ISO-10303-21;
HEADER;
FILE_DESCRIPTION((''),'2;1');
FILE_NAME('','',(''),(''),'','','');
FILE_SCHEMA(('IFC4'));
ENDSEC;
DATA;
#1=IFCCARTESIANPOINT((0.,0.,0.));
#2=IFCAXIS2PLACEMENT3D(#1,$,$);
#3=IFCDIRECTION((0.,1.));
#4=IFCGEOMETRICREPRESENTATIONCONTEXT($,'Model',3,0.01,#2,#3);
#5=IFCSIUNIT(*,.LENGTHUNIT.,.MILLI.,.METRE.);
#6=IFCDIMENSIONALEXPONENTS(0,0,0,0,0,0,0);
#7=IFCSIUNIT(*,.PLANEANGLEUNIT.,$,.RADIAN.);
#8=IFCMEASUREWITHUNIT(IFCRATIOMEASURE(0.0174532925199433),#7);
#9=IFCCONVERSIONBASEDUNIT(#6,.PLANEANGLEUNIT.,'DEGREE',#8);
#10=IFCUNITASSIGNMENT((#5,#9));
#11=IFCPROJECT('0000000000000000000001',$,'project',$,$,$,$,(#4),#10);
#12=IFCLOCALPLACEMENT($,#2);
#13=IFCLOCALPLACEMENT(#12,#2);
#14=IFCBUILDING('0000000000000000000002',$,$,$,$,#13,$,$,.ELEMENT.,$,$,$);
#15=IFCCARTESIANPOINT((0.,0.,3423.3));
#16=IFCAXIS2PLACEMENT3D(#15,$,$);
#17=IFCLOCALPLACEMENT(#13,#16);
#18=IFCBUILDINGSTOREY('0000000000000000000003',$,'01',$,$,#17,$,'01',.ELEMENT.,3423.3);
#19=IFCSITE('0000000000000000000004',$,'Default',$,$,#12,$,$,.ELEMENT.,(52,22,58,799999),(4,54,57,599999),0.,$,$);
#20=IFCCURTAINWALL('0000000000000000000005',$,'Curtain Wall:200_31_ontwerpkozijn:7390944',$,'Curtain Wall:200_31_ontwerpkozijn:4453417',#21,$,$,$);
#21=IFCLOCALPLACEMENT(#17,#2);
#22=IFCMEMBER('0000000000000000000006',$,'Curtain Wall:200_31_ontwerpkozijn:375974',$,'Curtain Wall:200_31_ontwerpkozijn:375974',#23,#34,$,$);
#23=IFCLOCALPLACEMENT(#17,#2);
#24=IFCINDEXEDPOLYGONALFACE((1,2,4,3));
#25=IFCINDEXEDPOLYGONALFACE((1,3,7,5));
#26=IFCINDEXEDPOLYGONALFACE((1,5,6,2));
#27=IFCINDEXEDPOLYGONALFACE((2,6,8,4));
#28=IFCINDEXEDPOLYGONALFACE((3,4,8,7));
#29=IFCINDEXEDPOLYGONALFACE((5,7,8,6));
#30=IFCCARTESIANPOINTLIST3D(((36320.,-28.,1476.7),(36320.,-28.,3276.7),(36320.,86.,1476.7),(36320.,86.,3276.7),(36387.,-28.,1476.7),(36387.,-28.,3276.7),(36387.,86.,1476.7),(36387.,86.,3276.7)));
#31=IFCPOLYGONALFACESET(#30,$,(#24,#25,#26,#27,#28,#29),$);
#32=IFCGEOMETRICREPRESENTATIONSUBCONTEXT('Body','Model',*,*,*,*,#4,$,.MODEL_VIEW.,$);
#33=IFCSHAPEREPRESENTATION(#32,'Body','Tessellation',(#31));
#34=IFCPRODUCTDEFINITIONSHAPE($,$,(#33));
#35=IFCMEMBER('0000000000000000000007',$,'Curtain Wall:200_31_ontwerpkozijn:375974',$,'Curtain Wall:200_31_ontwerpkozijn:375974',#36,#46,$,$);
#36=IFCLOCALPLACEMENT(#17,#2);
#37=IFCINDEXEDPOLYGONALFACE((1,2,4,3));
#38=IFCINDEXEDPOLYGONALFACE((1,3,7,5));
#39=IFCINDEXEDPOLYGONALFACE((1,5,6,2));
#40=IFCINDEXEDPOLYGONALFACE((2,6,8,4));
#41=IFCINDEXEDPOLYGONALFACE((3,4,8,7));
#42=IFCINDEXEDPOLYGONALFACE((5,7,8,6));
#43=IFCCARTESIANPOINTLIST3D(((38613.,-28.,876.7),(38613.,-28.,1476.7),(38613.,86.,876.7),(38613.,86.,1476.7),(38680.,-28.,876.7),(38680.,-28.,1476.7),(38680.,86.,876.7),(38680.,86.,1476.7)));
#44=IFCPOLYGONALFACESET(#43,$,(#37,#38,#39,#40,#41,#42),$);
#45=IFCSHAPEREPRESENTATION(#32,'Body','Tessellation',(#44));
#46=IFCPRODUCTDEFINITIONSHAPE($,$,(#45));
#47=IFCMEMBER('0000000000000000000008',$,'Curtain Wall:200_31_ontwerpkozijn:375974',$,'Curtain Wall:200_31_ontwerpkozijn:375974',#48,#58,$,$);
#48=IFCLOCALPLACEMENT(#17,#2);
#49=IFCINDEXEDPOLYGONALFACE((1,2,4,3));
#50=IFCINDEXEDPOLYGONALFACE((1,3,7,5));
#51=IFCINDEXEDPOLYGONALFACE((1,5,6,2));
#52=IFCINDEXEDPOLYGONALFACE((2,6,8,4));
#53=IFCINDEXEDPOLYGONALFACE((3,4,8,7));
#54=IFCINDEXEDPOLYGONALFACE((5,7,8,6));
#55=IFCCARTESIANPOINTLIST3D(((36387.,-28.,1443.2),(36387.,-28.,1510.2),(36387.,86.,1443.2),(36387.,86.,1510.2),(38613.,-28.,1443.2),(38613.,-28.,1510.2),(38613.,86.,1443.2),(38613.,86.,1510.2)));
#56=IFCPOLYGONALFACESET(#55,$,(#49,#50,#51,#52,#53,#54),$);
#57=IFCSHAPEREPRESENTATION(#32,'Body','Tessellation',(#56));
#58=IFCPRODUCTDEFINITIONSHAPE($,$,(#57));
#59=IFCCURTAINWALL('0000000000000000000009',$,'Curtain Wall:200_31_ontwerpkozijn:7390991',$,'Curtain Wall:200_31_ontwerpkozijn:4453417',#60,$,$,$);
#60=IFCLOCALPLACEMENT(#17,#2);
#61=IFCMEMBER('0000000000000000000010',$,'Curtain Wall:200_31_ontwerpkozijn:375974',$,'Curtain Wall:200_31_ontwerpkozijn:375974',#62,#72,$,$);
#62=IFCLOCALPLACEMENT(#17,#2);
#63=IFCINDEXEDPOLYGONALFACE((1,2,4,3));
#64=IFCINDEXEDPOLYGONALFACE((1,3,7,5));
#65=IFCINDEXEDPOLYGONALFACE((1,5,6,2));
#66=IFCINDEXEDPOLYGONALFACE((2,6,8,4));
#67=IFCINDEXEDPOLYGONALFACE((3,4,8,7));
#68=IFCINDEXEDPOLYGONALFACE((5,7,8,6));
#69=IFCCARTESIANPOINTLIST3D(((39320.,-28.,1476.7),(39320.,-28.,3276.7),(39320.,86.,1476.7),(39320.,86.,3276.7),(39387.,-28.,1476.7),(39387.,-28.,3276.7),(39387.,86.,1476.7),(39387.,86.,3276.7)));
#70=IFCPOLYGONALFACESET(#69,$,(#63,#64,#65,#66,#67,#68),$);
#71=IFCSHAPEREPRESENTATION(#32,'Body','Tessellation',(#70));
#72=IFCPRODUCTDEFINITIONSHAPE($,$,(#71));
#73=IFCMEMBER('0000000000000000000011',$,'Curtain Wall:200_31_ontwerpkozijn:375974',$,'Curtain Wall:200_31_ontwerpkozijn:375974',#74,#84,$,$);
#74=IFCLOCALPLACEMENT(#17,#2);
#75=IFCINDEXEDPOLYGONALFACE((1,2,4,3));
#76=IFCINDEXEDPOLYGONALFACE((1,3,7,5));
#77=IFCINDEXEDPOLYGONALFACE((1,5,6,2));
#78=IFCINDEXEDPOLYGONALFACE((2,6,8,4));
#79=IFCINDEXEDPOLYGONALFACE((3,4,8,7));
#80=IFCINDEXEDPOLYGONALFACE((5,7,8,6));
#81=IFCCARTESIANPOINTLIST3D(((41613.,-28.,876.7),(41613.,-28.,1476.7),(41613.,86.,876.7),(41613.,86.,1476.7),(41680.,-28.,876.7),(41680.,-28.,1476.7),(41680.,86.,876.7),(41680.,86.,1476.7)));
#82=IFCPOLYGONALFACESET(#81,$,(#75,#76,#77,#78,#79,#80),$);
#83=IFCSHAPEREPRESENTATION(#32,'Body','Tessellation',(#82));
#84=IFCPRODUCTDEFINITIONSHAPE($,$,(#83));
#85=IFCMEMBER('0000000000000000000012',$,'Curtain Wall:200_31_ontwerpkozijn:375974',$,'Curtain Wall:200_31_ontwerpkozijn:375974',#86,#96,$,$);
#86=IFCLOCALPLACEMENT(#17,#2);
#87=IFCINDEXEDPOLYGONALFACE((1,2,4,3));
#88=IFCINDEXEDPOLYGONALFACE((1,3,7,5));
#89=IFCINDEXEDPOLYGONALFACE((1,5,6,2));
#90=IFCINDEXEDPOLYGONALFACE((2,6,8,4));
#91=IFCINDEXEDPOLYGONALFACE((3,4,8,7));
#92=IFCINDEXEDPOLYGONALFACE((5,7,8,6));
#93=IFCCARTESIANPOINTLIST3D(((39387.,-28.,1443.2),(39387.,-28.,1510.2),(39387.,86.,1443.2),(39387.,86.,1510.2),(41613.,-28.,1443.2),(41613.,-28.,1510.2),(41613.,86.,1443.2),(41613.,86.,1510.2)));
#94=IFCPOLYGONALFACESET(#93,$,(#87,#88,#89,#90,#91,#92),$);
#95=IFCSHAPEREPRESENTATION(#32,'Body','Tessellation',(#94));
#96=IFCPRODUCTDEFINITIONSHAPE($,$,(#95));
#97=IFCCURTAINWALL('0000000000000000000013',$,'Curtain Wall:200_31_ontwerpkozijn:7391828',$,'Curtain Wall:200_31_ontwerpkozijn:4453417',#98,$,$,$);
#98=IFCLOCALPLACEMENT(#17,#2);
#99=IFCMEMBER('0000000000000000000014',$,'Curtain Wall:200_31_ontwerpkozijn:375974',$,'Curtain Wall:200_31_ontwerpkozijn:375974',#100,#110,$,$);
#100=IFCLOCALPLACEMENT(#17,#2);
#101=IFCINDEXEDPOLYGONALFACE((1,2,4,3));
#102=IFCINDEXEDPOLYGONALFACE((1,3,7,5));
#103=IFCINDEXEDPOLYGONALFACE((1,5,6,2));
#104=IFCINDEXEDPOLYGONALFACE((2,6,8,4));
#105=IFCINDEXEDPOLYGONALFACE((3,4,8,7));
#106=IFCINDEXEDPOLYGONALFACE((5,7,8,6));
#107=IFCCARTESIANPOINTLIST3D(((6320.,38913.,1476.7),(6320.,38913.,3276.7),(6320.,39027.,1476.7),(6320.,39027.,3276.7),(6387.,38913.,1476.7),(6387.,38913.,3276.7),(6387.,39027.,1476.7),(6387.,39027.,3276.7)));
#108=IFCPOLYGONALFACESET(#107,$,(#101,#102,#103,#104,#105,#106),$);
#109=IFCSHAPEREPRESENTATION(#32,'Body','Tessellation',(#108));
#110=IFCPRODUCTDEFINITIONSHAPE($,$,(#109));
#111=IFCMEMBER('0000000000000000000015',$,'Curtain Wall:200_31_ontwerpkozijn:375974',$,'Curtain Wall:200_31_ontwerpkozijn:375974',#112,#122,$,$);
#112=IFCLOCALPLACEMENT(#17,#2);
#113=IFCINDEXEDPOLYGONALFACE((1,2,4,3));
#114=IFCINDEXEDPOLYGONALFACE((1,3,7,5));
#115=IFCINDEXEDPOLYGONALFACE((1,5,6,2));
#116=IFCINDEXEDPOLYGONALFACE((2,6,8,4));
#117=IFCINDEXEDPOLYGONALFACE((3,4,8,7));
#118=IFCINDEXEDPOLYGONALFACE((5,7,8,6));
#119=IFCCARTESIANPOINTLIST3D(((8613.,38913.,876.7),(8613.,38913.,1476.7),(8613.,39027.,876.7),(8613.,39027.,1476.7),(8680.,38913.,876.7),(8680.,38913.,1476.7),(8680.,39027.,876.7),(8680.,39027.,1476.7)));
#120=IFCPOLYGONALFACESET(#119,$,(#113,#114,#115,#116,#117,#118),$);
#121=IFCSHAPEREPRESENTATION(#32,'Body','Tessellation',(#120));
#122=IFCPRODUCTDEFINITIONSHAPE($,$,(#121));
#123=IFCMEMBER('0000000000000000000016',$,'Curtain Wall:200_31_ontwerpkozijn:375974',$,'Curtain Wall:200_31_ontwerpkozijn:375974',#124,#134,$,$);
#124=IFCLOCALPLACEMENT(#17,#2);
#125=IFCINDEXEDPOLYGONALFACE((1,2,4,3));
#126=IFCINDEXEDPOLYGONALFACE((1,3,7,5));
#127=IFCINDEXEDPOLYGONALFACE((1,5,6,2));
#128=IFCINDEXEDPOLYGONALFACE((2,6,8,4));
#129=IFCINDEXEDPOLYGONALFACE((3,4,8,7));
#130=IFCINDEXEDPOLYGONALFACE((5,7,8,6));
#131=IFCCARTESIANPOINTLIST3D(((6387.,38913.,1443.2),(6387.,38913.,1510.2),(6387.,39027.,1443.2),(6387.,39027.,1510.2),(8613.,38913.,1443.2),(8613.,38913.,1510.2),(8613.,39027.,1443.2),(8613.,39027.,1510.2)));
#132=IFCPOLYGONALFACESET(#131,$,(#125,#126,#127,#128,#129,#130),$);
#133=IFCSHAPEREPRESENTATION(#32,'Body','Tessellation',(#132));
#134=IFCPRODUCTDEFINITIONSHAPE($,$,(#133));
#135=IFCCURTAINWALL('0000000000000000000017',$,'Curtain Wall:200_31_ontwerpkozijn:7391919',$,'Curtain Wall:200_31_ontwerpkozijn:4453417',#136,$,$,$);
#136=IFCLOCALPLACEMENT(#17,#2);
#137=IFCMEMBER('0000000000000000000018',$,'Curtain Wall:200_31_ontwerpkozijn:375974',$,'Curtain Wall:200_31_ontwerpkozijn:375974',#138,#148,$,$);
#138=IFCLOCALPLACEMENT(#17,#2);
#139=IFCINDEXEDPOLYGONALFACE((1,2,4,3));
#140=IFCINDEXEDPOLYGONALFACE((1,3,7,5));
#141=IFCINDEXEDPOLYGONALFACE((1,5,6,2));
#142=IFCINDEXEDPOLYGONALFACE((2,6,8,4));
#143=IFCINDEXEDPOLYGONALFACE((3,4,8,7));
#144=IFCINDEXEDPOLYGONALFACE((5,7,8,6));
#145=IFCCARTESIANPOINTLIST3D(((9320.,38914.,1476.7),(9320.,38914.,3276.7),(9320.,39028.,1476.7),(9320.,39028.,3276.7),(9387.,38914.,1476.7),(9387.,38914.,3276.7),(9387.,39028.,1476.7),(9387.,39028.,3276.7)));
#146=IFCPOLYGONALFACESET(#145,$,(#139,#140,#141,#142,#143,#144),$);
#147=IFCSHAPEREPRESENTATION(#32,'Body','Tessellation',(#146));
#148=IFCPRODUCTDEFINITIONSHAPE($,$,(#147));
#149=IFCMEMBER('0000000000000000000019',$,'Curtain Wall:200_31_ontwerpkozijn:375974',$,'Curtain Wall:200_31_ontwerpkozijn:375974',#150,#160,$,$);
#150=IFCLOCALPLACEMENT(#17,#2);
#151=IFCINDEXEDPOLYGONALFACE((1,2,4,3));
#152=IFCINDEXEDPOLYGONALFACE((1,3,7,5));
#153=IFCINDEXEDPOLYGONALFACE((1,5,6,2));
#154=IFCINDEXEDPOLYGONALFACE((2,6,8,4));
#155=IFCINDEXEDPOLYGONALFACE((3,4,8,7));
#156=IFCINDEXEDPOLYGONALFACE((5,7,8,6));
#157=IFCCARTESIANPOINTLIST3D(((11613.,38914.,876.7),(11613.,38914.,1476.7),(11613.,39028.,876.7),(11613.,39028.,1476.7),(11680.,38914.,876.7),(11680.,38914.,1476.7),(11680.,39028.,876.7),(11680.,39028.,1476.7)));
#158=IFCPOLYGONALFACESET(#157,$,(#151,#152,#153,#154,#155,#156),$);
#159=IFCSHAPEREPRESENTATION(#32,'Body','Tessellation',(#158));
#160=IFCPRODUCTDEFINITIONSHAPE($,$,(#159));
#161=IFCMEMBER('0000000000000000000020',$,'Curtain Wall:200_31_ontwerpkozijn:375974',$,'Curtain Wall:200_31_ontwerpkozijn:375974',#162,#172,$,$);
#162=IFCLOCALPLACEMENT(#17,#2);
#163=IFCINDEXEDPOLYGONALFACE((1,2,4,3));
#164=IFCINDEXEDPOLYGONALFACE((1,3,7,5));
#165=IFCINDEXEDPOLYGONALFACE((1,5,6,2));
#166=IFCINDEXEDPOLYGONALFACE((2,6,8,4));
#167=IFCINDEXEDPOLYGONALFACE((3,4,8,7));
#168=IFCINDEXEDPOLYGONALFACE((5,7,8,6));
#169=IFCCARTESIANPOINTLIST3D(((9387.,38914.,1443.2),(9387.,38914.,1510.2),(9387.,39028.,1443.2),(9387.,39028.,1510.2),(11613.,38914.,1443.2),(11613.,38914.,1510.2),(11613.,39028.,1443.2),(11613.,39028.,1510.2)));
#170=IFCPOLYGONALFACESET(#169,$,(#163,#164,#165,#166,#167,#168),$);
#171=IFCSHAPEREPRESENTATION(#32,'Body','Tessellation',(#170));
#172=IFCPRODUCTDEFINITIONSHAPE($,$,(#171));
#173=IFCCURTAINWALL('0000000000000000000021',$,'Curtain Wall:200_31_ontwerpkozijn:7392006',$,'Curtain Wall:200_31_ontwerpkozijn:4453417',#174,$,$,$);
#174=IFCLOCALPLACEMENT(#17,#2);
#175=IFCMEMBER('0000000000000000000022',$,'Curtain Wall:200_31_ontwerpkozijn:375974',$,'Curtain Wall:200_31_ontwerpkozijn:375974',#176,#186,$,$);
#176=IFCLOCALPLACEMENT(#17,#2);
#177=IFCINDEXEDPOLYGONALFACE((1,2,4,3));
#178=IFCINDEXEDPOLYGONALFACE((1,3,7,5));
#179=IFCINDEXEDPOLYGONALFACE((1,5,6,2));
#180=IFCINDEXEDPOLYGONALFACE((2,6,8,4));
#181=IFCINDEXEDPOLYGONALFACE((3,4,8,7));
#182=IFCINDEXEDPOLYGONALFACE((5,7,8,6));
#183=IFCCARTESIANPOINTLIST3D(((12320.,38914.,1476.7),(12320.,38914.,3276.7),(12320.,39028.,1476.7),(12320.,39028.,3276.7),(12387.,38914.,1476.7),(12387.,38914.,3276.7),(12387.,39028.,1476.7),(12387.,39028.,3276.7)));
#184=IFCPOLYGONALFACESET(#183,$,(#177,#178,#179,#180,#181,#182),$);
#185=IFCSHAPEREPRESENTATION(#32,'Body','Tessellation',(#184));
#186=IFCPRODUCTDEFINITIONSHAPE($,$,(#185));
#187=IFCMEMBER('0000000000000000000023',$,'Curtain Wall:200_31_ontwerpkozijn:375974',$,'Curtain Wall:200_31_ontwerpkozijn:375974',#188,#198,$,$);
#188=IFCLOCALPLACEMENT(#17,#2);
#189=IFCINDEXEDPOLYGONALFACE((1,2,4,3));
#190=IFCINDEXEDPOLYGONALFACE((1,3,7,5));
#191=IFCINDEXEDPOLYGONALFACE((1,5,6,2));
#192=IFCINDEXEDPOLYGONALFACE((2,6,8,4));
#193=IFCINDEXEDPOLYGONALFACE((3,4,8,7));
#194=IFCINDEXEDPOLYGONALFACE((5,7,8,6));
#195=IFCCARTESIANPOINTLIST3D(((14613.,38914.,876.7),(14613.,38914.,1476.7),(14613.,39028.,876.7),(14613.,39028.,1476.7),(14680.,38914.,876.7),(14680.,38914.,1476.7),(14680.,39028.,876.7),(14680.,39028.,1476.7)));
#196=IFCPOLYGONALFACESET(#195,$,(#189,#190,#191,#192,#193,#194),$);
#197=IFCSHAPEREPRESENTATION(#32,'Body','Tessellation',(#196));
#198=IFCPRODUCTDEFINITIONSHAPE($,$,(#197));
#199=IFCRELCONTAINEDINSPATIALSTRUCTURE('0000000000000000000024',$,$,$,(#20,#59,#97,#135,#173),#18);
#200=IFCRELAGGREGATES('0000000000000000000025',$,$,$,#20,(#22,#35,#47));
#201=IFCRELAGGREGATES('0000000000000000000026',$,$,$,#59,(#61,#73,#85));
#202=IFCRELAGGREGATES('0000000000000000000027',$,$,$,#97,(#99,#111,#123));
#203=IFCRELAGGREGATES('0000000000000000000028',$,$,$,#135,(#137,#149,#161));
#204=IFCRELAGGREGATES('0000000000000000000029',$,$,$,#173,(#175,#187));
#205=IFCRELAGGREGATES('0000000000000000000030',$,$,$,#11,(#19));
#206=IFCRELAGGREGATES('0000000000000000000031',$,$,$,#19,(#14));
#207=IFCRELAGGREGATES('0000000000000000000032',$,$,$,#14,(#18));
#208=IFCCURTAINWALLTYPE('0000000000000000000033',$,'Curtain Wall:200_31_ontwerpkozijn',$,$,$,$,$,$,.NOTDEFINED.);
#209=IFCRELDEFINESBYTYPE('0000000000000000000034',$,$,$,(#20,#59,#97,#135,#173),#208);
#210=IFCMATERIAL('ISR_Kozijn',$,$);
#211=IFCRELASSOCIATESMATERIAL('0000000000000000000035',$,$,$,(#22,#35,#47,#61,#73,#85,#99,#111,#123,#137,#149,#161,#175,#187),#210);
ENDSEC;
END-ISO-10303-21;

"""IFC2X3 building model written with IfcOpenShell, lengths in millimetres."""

from ifc_helpers import new_model, entity, si_unit, converted_unit, direction, frame, frame_2d, origin, origin_2d_with_axis, place, context, subcontext, project, spatial, rectangle, extrude, material, type_object, element, aggregate, save


model = new_model("IFC2X3")

# Units and contexts
model_context = context("Model", 3, precision=0.01, world=origin(), true_north=direction((0.0, 1.0)))
body_context = subcontext(model_context, "Body", "Model", "MODEL_VIEW")
ifc_project = project(units=[si_unit("LENGTHUNIT", "METRE", prefix="MILLI"), converted_unit("PLANEANGLEUNIT", "DEGREE", entity("IfcRatioMeasure", 0.0174532925199433), si_unit("PLANEANGLEUNIT", "RADIAN"), dimensions=[0, 0, 0, 0, 0, 0, 0])], contexts=[model_context])

# Site, building, storey
site_placement = place(None, origin())
site = spatial("IfcSite", under=ifc_project, at=site_placement, Name="Default", CompositionType="ELEMENT", RefLatitude=(52, 22, 58, 799999), RefLongitude=(4, 54, 57, 599999), RefElevation=0.0)
building_placement = place(site_placement, origin())
building = spatial("IfcBuilding", under=site, at=building_placement, CompositionType="ELEMENT")
storey_placement = place(building_placement, frame((0.0, 0.0, 3423.3)))
storey = spatial("IfcBuildingStorey", under=building, at=storey_placement, Name="01", LongName="01", CompositionType="ELEMENT", Elevation=3423.3)

# Curtain walls, members
curtain_wall_type = type_object("IfcCurtainWallType", Name="Curtain Wall:200_31_ontwerpkozijn", PredefinedType="NOTDEFINED")
curtain_wall_1_placement = place(storey_placement, frame((0.0, 0.0, -3423.3)))
curtain_wall_1 = element("IfcCurtainWall", 1, at=curtain_wall_1_placement, inside=storey, type_object=curtain_wall_type, Name="Curtain Wall:200_31_ontwerpkozijn:7390944", ObjectType="Curtain Wall:200_31_ontwerpkozijn:4453417")
ifc_material = material(Name="ISR_Kozijn")
member_1_placement = place(curtain_wall_1_placement, frame((0.0, 0.0, 3423.3)))
member_1 = element("IfcMember", 2, at=member_1_placement, material=ifc_material, Name="Curtain Wall:200_31_ontwerpkozijn:375974", ObjectType="Curtain Wall:200_31_ontwerpkozijn:375974", context=body_context, shape_type="SweptSolid", body=[
    extrude(rectangle(XDim=67.0, YDim=114.0, at=origin_2d_with_axis()), frame((36353.5, 29.0, 1476.7), z_axis=(0.0, 0.0, 1.0), x_axis=(-1.0, 0.0, 0.0)), (0.0, 0.0, 1.0), 1800.0),
])
member_2_placement = place(curtain_wall_1_placement, frame((0.0, 0.0, 3423.3)))
member_2 = element("IfcMember", 3, at=member_2_placement, material=ifc_material, Name="Curtain Wall:200_31_ontwerpkozijn:375974", ObjectType="Curtain Wall:200_31_ontwerpkozijn:375974", context=body_context, shape_type="SweptSolid", body=[
    extrude(rectangle(XDim=67.0, YDim=114.0, at=origin_2d_with_axis()), frame((38646.5, 29.0, 1476.7), z_axis=(0.0, 0.0, -1.0), x_axis=(-1.0, 0.0, 0.0)), (0.0, 0.0, 1.0), 600.0),
])
member_3_placement = place(curtain_wall_1_placement, frame((0.0, 0.0, 3423.3)))
member_3 = element("IfcMember", 4, at=member_3_placement, material=ifc_material, Name="Curtain Wall:200_31_ontwerpkozijn:375974", ObjectType="Curtain Wall:200_31_ontwerpkozijn:375974", context=body_context, shape_type="SweptSolid", body=[
    extrude(rectangle(XDim=67.0, YDim=114.0, at=origin_2d_with_axis()), frame((36387.0, 29.0, 1476.7), z_axis=(1.0, 0.0, 0.0), x_axis=(0.0, 0.0, -1.0)), (0.0, 0.0, 1.0), 2226.0),
])
aggregate(curtain_wall_1, [member_1, member_2, member_3])
curtain_wall_2_placement = place(storey_placement, frame((0.0, 0.0, -3423.3)))
curtain_wall_2 = element("IfcCurtainWall", 5, at=curtain_wall_2_placement, inside=storey, type_object=curtain_wall_type, Name="Curtain Wall:200_31_ontwerpkozijn:7390991", ObjectType="Curtain Wall:200_31_ontwerpkozijn:4453417")
member_4_placement = place(curtain_wall_2_placement, frame((0.0, 0.0, 3423.3)))
member_4 = element("IfcMember", 6, at=member_4_placement, material=ifc_material, Name="Curtain Wall:200_31_ontwerpkozijn:375974", ObjectType="Curtain Wall:200_31_ontwerpkozijn:375974", context=body_context, shape_type="SweptSolid", body=[
    extrude(rectangle(XDim=67.0, YDim=114.0, at=origin_2d_with_axis()), frame((39353.5, 29.0, 1476.7), z_axis=(0.0, 0.0, 1.0), x_axis=(-1.0, 0.0, 0.0)), (0.0, 0.0, 1.0), 1800.0),
])
member_5_placement = place(curtain_wall_2_placement, frame((0.0, 0.0, 3423.3)))
member_5 = element("IfcMember", 7, at=member_5_placement, material=ifc_material, Name="Curtain Wall:200_31_ontwerpkozijn:375974", ObjectType="Curtain Wall:200_31_ontwerpkozijn:375974", context=body_context, shape_type="SweptSolid", body=[
    extrude(rectangle(XDim=67.0, YDim=114.0, at=origin_2d_with_axis()), frame((41646.5, 29.0, 1476.7), z_axis=(0.0, 0.0, -1.0), x_axis=(-1.0, 0.0, 0.0)), (0.0, 0.0, 1.0), 600.0),
])
member_6_placement = place(curtain_wall_2_placement, frame((0.0, 0.0, 3423.3)))
member_6 = element("IfcMember", 8, at=member_6_placement, material=ifc_material, Name="Curtain Wall:200_31_ontwerpkozijn:375974", ObjectType="Curtain Wall:200_31_ontwerpkozijn:375974", context=body_context, shape_type="SweptSolid", body=[
    extrude(rectangle(XDim=67.0, YDim=114.0, at=origin_2d_with_axis()), frame((39387.0, 29.0, 1476.7), z_axis=(1.0, 0.0, 0.0), x_axis=(0.0, 0.0, -1.0)), (0.0, 0.0, 1.0), 2226.0),
])
aggregate(curtain_wall_2, [member_4, member_5, member_6])
curtain_wall_3_placement = place(storey_placement, frame((0.0, 0.0, -3423.3)))
curtain_wall_3 = element("IfcCurtainWall", 9, at=curtain_wall_3_placement, inside=storey, type_object=curtain_wall_type, Name="Curtain Wall:200_31_ontwerpkozijn:7391828", ObjectType="Curtain Wall:200_31_ontwerpkozijn:4453417")
member_7_placement = place(curtain_wall_3_placement, frame((0.0, 0.0, 3423.3)))
member_7 = element("IfcMember", 10, at=member_7_placement, material=ifc_material, Name="Curtain Wall:200_31_ontwerpkozijn:375974", ObjectType="Curtain Wall:200_31_ontwerpkozijn:375974", context=body_context, shape_type="SweptSolid", body=[
    extrude(rectangle(XDim=67.0, YDim=114.0, at=frame_2d((0.0, 0.0), x_axis=(1.0, 0.0))), frame((6353.5, 38970.0, 1476.7), z_axis=(0.0, 0.0, 1.0), x_axis=(-1.0, 0.0, 0.0)), (0.0, 0.0, 1.0), 1800.0),
])
member_8_placement = place(curtain_wall_3_placement, frame((0.0, 0.0, 3423.3)))
member_8 = element("IfcMember", 11, at=member_8_placement, material=ifc_material, Name="Curtain Wall:200_31_ontwerpkozijn:375974", ObjectType="Curtain Wall:200_31_ontwerpkozijn:375974", context=body_context, shape_type="SweptSolid", body=[
    extrude(rectangle(XDim=67.0, YDim=114.0, at=frame_2d((0.0, 0.0), x_axis=(1.0, 0.0))), frame((8646.5, 38970.0, 1476.7), z_axis=(0.0, 0.0, -1.0), x_axis=(-1.0, 0.0, 0.0)), (0.0, 0.0, 1.0), 600.0),
])
member_9_placement = place(curtain_wall_3_placement, frame((0.0, 0.0, 3423.3)))
member_9 = element("IfcMember", 12, at=member_9_placement, material=ifc_material, Name="Curtain Wall:200_31_ontwerpkozijn:375974", ObjectType="Curtain Wall:200_31_ontwerpkozijn:375974", context=body_context, shape_type="SweptSolid", body=[
    extrude(rectangle(XDim=67.0, YDim=114.0, at=frame_2d((0.0, 0.0), x_axis=(1.0, 0.0))), frame((6387.0, 38970.0, 1476.7), z_axis=(1.0, 0.0, 0.0), x_axis=(0.0, 0.0, -1.0)), (0.0, 0.0, 1.0), 2226.0),
])
aggregate(curtain_wall_3, [member_7, member_8, member_9])
curtain_wall_4_placement = place(storey_placement, frame((0.0, 0.0, -3423.3)))
curtain_wall_4 = element("IfcCurtainWall", 13, at=curtain_wall_4_placement, inside=storey, type_object=curtain_wall_type, Name="Curtain Wall:200_31_ontwerpkozijn:7391919", ObjectType="Curtain Wall:200_31_ontwerpkozijn:4453417")
member_10_placement = place(curtain_wall_4_placement, frame((0.0, 0.0, 3423.3)))
member_10 = element("IfcMember", 14, at=member_10_placement, material=ifc_material, Name="Curtain Wall:200_31_ontwerpkozijn:375974", ObjectType="Curtain Wall:200_31_ontwerpkozijn:375974", context=body_context, shape_type="SweptSolid", body=[
    extrude(rectangle(XDim=67.0, YDim=114.0, at=frame_2d((0.0, 0.0), x_axis=(1.0, 0.0))), frame((9353.5, 38971.0, 1476.7), z_axis=(0.0, 0.0, 1.0), x_axis=(-1.0, 0.0, 0.0)), (0.0, 0.0, 1.0), 1800.0),
])
member_11_placement = place(curtain_wall_4_placement, frame((0.0, 0.0, 3423.3)))
member_11 = element("IfcMember", 15, at=member_11_placement, material=ifc_material, Name="Curtain Wall:200_31_ontwerpkozijn:375974", ObjectType="Curtain Wall:200_31_ontwerpkozijn:375974", context=body_context, shape_type="SweptSolid", body=[
    extrude(rectangle(XDim=67.0, YDim=114.0, at=frame_2d((0.0, 0.0), x_axis=(1.0, 0.0))), frame((11646.5, 38971.0, 1476.7), z_axis=(0.0, 0.0, -1.0), x_axis=(-1.0, 0.0, 0.0)), (0.0, 0.0, 1.0), 600.0),
])
member_12_placement = place(curtain_wall_4_placement, frame((0.0, 0.0, 3423.3)))
member_12 = element("IfcMember", 16, at=member_12_placement, material=ifc_material, Name="Curtain Wall:200_31_ontwerpkozijn:375974", ObjectType="Curtain Wall:200_31_ontwerpkozijn:375974", context=body_context, shape_type="SweptSolid", body=[
    extrude(rectangle(XDim=67.0, YDim=114.0, at=frame_2d((0.0, 0.0), x_axis=(1.0, 0.0))), frame((9387.0, 38971.0, 1476.7), z_axis=(1.0, 0.0, 0.0), x_axis=(0.0, 0.0, -1.0)), (0.0, 0.0, 1.0), 2226.0),
])
aggregate(curtain_wall_4, [member_10, member_11, member_12])
curtain_wall_5_placement = place(storey_placement, frame((0.0, 0.0, -3423.3)))
curtain_wall_5 = element("IfcCurtainWall", 17, at=curtain_wall_5_placement, inside=storey, type_object=curtain_wall_type, Name="Curtain Wall:200_31_ontwerpkozijn:7392006", ObjectType="Curtain Wall:200_31_ontwerpkozijn:4453417")
member_13_placement = place(curtain_wall_5_placement, frame((0.0, 0.0, 3423.3)))
member_13 = element("IfcMember", 18, at=member_13_placement, material=ifc_material, Name="Curtain Wall:200_31_ontwerpkozijn:375974", ObjectType="Curtain Wall:200_31_ontwerpkozijn:375974", context=body_context, shape_type="SweptSolid", body=[
    extrude(rectangle(XDim=67.0, YDim=114.0, at=frame_2d((0.0, 0.0), x_axis=(1.0, 0.0))), frame((12353.5, 38971.0, 1476.7), z_axis=(0.0, 0.0, 1.0), x_axis=(-1.0, 0.0, 0.0)), (0.0, 0.0, 1.0), 1800.0),
])
member_14_placement = place(curtain_wall_5_placement, frame((0.0, 0.0, 3423.3)))
member_14 = element("IfcMember", 19, at=member_14_placement, material=ifc_material, Name="Curtain Wall:200_31_ontwerpkozijn:375974", ObjectType="Curtain Wall:200_31_ontwerpkozijn:375974", context=body_context, shape_type="SweptSolid", body=[
    extrude(rectangle(XDim=67.0, YDim=114.0, at=frame_2d((0.0, 0.0), x_axis=(1.0, 0.0))), frame((14646.5, 38971.0, 1476.7), z_axis=(0.0, 0.0, -1.0), x_axis=(-1.0, 0.0, 0.0)), (0.0, 0.0, 1.0), 600.0),
])
aggregate(curtain_wall_5, [member_13, member_14])

save(model, "model.ifc")
